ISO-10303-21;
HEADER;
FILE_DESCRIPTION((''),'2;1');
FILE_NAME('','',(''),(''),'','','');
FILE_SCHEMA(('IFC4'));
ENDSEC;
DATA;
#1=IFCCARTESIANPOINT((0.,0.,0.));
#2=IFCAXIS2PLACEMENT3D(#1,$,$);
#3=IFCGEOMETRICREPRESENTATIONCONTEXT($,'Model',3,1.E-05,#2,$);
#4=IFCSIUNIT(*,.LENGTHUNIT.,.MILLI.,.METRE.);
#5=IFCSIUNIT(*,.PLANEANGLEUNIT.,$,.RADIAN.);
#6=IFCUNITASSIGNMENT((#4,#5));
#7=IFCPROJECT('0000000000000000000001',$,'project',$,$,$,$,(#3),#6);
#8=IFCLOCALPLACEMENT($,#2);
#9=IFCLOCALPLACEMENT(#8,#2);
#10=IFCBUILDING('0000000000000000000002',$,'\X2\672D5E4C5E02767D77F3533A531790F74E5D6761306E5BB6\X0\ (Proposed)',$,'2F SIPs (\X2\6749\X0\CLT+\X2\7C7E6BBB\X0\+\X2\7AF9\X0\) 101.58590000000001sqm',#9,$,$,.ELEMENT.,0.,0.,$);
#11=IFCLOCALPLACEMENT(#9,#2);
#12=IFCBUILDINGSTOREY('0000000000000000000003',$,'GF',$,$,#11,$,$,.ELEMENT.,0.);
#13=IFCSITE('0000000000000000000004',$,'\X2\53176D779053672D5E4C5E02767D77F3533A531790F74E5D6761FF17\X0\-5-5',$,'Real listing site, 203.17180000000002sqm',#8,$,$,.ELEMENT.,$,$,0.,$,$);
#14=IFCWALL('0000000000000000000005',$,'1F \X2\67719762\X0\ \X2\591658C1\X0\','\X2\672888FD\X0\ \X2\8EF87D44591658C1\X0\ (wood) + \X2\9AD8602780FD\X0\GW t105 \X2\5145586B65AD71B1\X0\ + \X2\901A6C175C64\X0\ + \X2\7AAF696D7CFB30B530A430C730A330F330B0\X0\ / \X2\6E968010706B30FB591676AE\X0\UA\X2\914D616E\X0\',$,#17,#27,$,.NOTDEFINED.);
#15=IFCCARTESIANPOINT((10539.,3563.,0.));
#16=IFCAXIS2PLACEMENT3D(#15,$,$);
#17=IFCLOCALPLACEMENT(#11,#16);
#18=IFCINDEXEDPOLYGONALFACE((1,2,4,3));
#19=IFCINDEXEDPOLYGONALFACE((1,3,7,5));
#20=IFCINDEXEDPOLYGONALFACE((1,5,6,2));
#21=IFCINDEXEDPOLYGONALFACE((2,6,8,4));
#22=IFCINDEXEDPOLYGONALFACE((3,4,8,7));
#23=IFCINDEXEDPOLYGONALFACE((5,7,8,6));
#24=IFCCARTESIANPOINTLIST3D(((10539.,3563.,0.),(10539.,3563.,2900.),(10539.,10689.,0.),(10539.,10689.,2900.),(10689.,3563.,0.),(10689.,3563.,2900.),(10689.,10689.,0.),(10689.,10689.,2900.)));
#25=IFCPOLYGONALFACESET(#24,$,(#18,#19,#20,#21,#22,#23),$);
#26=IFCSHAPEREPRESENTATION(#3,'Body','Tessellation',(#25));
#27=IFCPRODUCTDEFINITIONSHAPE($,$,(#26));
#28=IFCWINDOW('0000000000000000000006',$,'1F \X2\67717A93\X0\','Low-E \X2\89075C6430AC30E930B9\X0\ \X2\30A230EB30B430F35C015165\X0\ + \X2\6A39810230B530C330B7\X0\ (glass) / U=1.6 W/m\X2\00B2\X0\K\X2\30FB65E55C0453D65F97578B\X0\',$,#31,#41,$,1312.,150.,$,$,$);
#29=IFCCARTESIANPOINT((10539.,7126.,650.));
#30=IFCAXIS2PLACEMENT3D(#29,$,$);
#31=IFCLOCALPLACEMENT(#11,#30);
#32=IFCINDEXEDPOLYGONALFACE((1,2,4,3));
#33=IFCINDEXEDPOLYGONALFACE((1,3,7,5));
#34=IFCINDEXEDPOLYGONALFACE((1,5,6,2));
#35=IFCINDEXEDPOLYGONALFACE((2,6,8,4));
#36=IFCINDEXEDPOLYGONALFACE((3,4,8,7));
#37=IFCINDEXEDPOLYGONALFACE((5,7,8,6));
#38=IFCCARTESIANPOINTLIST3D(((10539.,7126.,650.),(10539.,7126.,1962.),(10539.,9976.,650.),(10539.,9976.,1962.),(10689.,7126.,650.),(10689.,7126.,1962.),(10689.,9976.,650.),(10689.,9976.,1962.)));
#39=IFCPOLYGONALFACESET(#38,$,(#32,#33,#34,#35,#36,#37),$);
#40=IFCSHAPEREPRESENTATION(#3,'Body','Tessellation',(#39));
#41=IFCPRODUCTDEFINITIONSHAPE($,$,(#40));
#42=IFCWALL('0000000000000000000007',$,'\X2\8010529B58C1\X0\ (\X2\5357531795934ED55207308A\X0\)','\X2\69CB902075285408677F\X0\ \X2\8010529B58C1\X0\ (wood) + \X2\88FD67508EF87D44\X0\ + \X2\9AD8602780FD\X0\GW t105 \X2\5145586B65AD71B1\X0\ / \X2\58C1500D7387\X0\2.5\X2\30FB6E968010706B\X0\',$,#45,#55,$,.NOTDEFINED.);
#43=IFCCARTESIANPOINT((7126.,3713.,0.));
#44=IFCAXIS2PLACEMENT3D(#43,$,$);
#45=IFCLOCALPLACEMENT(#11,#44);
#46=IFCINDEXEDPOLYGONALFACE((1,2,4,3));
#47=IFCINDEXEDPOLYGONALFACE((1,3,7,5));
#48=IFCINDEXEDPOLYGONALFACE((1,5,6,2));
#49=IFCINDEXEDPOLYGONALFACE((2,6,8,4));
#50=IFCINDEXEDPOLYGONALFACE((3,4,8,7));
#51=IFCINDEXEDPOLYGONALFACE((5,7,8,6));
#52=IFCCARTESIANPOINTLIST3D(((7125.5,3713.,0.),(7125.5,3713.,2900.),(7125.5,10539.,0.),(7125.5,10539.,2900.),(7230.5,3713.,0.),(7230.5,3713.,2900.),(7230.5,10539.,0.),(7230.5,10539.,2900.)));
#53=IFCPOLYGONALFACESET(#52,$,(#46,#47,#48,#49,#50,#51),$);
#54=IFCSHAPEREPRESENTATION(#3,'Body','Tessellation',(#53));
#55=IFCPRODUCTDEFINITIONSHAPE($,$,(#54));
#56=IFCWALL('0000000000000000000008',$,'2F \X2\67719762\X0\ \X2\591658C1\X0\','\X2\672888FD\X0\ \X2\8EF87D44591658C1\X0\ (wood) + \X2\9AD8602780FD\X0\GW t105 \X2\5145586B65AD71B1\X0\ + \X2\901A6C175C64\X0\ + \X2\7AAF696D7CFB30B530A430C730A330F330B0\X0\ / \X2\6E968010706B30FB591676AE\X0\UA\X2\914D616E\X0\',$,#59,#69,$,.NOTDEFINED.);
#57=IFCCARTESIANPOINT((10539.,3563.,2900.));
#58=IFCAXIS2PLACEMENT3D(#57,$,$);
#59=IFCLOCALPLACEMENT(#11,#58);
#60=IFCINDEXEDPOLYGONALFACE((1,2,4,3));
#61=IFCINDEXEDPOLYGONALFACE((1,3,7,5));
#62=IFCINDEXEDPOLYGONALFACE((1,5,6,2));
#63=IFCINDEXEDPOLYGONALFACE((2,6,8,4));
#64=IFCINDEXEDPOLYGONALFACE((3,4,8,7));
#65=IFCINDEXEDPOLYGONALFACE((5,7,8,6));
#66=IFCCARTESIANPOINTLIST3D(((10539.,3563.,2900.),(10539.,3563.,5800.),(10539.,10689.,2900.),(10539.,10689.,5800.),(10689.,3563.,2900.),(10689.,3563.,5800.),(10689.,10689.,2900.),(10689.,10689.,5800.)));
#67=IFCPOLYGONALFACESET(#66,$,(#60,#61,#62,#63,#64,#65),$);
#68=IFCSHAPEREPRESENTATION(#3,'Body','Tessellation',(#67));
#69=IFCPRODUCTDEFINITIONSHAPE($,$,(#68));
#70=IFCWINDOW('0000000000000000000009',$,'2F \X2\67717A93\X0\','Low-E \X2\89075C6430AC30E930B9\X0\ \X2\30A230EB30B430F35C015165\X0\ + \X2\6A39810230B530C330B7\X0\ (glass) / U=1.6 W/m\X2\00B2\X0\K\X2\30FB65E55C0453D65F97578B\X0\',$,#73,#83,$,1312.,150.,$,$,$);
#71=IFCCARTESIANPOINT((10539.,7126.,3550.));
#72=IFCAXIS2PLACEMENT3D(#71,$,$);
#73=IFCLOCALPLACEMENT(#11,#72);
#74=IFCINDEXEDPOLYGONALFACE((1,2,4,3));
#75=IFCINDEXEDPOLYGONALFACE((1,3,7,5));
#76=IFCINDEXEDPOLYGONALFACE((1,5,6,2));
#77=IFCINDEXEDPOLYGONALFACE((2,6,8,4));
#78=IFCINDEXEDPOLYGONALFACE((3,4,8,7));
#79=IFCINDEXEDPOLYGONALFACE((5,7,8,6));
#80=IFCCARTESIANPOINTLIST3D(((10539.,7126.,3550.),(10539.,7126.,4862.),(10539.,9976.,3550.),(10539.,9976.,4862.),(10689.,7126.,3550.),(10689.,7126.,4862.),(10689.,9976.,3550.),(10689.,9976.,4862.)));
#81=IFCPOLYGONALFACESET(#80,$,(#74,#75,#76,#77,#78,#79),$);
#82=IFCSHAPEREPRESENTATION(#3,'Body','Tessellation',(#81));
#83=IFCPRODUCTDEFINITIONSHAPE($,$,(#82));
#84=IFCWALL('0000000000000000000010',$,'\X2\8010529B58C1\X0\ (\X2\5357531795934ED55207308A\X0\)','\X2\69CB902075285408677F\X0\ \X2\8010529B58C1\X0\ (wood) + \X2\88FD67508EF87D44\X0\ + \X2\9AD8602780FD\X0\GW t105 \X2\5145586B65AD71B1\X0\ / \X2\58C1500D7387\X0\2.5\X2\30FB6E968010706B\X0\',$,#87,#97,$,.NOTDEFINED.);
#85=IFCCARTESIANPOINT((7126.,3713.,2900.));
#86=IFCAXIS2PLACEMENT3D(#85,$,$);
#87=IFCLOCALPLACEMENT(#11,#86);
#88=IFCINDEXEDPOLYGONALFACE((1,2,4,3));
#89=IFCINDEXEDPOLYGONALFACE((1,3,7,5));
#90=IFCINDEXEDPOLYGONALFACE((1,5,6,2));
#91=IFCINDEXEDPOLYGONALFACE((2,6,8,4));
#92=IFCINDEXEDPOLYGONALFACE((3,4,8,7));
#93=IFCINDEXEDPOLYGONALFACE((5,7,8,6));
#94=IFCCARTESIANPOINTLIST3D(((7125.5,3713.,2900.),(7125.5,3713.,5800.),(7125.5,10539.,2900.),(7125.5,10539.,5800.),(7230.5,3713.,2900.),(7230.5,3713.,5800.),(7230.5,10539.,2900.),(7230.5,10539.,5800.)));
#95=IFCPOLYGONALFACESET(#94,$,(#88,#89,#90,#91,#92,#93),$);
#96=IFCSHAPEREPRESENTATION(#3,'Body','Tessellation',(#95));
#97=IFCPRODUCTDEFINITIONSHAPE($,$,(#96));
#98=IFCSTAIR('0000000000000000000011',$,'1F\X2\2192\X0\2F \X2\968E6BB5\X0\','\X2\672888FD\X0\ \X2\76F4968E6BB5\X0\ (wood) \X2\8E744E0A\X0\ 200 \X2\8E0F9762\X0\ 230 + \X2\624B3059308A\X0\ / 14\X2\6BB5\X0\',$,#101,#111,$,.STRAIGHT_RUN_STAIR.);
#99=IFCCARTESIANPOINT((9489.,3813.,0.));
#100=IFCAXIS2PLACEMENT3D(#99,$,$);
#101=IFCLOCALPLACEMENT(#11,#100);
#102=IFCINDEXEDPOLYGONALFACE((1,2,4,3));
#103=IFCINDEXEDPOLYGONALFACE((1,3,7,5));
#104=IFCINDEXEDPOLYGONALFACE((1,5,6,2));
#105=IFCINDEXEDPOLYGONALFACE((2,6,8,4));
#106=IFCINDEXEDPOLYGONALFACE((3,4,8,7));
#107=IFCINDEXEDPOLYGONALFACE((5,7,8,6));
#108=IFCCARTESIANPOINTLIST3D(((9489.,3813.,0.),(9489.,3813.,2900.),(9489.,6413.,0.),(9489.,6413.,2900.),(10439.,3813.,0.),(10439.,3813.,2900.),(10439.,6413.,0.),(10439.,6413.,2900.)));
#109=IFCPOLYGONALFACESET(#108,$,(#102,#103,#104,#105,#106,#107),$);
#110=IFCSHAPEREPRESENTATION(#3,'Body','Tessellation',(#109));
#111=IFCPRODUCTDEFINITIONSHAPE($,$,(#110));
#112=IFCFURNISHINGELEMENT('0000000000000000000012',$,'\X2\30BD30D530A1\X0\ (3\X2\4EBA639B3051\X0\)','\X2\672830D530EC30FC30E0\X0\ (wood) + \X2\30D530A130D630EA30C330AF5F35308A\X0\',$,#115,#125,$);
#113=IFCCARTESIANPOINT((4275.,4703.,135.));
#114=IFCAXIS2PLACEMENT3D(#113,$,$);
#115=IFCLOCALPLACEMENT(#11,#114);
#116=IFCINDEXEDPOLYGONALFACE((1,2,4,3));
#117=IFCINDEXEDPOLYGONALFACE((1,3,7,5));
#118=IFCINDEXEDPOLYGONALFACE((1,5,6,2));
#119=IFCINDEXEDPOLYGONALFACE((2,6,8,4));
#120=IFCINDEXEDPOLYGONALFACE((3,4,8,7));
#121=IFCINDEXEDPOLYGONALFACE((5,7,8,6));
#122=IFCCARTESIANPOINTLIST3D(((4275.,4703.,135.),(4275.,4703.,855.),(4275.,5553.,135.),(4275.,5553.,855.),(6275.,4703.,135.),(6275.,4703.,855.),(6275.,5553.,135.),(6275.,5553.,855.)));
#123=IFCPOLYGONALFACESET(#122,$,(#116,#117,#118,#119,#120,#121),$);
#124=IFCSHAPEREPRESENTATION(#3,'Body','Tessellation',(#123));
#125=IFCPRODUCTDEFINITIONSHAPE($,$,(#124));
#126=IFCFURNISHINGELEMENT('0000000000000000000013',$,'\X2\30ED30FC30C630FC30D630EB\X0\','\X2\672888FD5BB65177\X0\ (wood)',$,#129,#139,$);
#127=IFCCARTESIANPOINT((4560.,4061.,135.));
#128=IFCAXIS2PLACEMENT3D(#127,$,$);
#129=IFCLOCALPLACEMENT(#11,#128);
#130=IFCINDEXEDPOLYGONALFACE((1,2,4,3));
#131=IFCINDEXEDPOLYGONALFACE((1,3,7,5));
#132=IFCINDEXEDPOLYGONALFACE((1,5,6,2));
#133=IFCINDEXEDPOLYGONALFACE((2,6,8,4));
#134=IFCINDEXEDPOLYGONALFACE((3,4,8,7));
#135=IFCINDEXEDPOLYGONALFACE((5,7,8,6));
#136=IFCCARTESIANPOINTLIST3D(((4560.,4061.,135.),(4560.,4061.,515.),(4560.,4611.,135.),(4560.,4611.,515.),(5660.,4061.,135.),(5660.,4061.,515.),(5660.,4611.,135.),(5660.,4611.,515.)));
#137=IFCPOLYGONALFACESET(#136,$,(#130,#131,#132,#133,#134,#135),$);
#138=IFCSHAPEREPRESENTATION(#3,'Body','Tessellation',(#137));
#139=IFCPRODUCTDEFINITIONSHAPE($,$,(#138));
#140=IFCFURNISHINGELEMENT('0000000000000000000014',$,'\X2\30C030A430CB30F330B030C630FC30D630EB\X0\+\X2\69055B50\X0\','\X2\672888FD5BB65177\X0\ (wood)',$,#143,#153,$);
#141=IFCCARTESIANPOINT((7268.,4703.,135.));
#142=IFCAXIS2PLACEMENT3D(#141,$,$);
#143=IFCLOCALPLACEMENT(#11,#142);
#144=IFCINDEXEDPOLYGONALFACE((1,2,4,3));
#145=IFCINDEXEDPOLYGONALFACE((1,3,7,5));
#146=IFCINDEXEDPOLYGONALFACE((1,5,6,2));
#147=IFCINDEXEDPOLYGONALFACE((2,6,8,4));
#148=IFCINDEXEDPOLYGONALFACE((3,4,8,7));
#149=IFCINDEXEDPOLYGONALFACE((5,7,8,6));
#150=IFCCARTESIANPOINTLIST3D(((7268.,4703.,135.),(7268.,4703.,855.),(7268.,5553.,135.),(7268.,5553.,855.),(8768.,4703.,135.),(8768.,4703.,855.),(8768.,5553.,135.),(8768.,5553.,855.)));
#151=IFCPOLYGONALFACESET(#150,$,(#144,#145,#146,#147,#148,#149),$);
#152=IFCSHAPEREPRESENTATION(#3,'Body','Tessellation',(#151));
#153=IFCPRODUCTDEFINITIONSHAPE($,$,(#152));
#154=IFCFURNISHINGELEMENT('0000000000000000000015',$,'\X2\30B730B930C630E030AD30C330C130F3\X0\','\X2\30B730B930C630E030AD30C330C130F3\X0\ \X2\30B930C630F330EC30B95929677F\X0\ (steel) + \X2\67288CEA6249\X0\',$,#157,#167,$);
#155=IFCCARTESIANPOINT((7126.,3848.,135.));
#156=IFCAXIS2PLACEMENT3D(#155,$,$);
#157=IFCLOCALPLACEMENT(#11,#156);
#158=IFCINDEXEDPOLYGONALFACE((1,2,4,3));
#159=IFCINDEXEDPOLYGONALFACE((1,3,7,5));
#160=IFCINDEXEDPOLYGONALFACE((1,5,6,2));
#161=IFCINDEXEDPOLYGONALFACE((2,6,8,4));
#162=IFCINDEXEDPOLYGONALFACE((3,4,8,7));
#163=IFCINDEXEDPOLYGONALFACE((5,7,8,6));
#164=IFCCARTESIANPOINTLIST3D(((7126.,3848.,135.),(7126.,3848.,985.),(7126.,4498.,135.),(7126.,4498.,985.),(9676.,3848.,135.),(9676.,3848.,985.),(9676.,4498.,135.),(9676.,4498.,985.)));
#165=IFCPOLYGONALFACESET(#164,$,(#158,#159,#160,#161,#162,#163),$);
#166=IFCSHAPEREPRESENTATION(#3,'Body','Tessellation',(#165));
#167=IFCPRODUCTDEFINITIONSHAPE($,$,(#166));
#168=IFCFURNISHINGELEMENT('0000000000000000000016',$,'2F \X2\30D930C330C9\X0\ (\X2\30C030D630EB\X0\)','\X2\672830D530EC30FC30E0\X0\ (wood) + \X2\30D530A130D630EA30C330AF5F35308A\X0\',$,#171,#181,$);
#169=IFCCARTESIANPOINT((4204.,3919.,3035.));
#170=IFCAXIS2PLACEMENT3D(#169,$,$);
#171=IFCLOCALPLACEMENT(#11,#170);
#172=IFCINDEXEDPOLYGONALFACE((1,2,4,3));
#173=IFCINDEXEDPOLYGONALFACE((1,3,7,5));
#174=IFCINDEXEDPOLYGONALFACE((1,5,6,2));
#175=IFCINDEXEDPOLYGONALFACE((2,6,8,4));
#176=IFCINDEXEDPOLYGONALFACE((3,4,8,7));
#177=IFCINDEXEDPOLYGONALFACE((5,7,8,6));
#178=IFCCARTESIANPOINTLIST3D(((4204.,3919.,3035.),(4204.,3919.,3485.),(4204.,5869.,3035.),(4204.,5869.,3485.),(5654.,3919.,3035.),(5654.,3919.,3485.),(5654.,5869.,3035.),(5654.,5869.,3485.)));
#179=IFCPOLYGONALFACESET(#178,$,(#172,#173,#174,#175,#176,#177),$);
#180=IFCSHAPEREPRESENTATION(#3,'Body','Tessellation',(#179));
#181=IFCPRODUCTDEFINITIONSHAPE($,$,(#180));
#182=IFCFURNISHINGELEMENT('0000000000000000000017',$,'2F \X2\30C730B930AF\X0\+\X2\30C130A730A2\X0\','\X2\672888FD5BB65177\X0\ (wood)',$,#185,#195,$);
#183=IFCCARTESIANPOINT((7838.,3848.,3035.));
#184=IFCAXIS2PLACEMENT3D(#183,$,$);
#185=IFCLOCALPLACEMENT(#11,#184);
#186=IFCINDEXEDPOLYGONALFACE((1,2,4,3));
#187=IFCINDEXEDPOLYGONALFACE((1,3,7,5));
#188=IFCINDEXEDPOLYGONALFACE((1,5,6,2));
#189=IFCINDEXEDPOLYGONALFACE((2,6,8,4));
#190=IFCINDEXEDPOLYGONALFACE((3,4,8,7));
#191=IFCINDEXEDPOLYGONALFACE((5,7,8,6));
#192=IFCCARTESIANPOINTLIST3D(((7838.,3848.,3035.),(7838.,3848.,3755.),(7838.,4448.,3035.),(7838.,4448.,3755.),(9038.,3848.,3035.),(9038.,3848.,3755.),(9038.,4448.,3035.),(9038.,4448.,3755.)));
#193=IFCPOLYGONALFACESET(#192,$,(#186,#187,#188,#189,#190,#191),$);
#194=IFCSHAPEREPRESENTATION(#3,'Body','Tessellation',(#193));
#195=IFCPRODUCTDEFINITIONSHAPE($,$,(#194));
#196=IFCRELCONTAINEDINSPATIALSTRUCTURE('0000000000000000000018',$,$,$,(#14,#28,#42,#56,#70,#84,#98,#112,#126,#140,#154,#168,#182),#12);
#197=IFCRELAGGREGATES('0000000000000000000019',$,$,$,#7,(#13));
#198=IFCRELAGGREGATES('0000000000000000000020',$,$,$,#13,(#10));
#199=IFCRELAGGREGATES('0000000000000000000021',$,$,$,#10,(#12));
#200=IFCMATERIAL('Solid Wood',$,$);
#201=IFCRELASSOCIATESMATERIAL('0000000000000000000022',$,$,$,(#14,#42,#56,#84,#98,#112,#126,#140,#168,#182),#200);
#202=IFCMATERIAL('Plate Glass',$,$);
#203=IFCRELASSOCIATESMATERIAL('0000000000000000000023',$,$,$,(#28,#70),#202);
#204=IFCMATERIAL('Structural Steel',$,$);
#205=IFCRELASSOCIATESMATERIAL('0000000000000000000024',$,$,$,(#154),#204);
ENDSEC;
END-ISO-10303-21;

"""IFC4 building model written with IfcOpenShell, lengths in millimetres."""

from ifc_helpers import new_model, si_unit, frame, frame_2d, origin, place, context, project, spatial, rectangle, extrude, material, element, fill, save


model = new_model("IFC4")

# Units and contexts
model_context = context("Model", 3, precision=1e-05, world=origin())
ifc_project = project(units=[si_unit("LENGTHUNIT", "METRE", prefix="MILLI"), si_unit("PLANEANGLEUNIT", "RADIAN")], contexts=[model_context])

# Site, building, storey
site_placement = place(None, origin())
site = spatial("IfcSite", under=ifc_project, at=site_placement, Name="北海道札幌市白石区北郷九条７-5-5", ObjectType="Real listing site, 203.17180000000002sqm", CompositionType="ELEMENT", RefElevation=0.0)
building_placement = place(site_placement, origin())
building = spatial("IfcBuilding", under=site, at=building_placement, Name="札幌市白石区北郷九条の家 (Proposed)", ObjectType="2F SIPs (杉CLT+籾殻+竹) 101.58590000000001sqm", CompositionType="ELEMENT", ElevationOfRefHeight=0.0, ElevationOfTerrain=0.0)
storey_placement = place(building_placement, origin())
storey = spatial("IfcBuildingStorey", under=building, at=storey_placement, Name="GF", CompositionType="ELEMENT", Elevation=0.0)

# Wall, opening, window
ifc_material_1 = material(Name="Solid Wood")
wall_1_placement = place(storey_placement, frame((10539.0, 3563.0, 0.0)))
wall_1 = element("IfcWall", 1, at=wall_1_placement, inside=storey, material=ifc_material_1, Name="1F 東面 外壁", Description="木製 軸組外壁 (wood) + 高性能GW t105 充填断熱 + 通気層 + 窯業系サイディング / 準耐火・外皮UA配慮", PredefinedType="NOTDEFINED", context=model_context, shape_type="SweptSolid", body=[
    extrude(rectangle(XDim=150.0, YDim=7126.0, at=frame_2d((75.0, 3563.0))), frame((10539.0, 3563.0, 0.0)), (0.0, 0.0, 1.0), 2900.0),
])
opening_1_placement = place(storey_placement, frame((10539.0, 7126.0, 650.0)))
opening_1 = element("IfcOpeningElement", 2, at=opening_1_placement, cuts=wall_1, PredefinedType="NOTDEFINED", context=model_context, shape_type="SweptSolid", body=[
    extrude(rectangle(XDim=150.0, YDim=2850.0, at=frame_2d((75.0, 1425.0))), frame((10539.0, 7126.0, 650.0)), (0.0, 0.0, 1.0), 1312.0),
])
ifc_material_2 = material(Name="Plate Glass")
window_1_placement = place(storey_placement, frame((10539.0, 7126.0, 650.0)))
window_1 = element("IfcWindow", 3, at=window_1_placement, inside=storey, material=ifc_material_2, Name="1F 東窓", Description="Low-E 複層ガラス アルゴン封入 + 樹脂サッシ (glass) / U=1.6 W/m²K・日射取得型", OverallHeight=1312.0, OverallWidth=150.0, context=model_context, shape_type="SweptSolid", body=[
    extrude(rectangle(XDim=150.0, YDim=2850.0, at=frame_2d((75.0, 1425.0))), frame((10539.0, 7126.0, 650.0)), (0.0, 0.0, 1.0), 1312.0),
])
fill(opening_1, window_1)

# Wall
wall_2_placement = place(storey_placement, frame((7126.0, 3713.0, 0.0)))
element("IfcWall", 4, at=wall_2_placement, inside=storey, material=ifc_material_1, Name="耐力壁 (南北間仕切り)", Description="構造用合板 耐力壁 (wood) + 製材軸組 + 高性能GW t105 充填断熱 / 壁倍率2.5・準耐火", PredefinedType="NOTDEFINED", context=model_context, shape_type="SweptSolid", body=[
    extrude(rectangle(XDim=105.0, YDim=6826.0, at=frame_2d((52.0, 3413.0))), frame((7126.0, 3713.0, 0.0)), (0.0, 0.0, 1.0), 2900.0),
])

# Wall, opening, window
wall_3_placement = place(storey_placement, frame((10539.0, 3563.0, 2900.0)))
wall_3 = element("IfcWall", 5, at=wall_3_placement, inside=storey, material=ifc_material_1, Name="2F 東面 外壁", Description="木製 軸組外壁 (wood) + 高性能GW t105 充填断熱 + 通気層 + 窯業系サイディング / 準耐火・外皮UA配慮", PredefinedType="NOTDEFINED", context=model_context, shape_type="SweptSolid", body=[
    extrude(rectangle(XDim=150.0, YDim=7126.0, at=frame_2d((75.0, 3563.0))), frame((10539.0, 3563.0, 2900.0)), (0.0, 0.0, 1.0), 2900.0),
])
opening_2_placement = place(storey_placement, frame((10539.0, 7126.0, 3550.0)))
opening_2 = element("IfcOpeningElement", 6, at=opening_2_placement, cuts=wall_3, PredefinedType="NOTDEFINED", context=model_context, shape_type="SweptSolid", body=[
    extrude(rectangle(XDim=150.0, YDim=2850.0, at=frame_2d((75.0, 1425.0))), frame((10539.0, 7126.0, 3550.0)), (0.0, 0.0, 1.0), 1312.0),
])
window_2_placement = place(storey_placement, frame((10539.0, 7126.0, 3550.0)))
window_2 = element("IfcWindow", 7, at=window_2_placement, inside=storey, material=ifc_material_2, Name="2F 東窓", Description="Low-E 複層ガラス アルゴン封入 + 樹脂サッシ (glass) / U=1.6 W/m²K・日射取得型", OverallHeight=1312.0, OverallWidth=150.0, context=model_context, shape_type="SweptSolid", body=[
    extrude(rectangle(XDim=150.0, YDim=2850.0, at=frame_2d((75.0, 1425.0))), frame((10539.0, 7126.0, 3550.0)), (0.0, 0.0, 1.0), 1312.0),
])
fill(opening_2, window_2)

# Wall
wall_4_placement = place(storey_placement, frame((7126.0, 3713.0, 2900.0)))
element("IfcWall", 8, at=wall_4_placement, inside=storey, material=ifc_material_1, Name="耐力壁 (南北間仕切り)", Description="構造用合板 耐力壁 (wood) + 製材軸組 + 高性能GW t105 充填断熱 / 壁倍率2.5・準耐火", PredefinedType="NOTDEFINED", context=model_context, shape_type="SweptSolid", body=[
    extrude(rectangle(XDim=105.0, YDim=6826.0, at=frame_2d((52.0, 3413.0))), frame((7126.0, 3713.0, 2900.0)), (0.0, 0.0, 1.0), 2900.0),
])

# Stair
stair_placement = place(storey_placement, frame((9489.0, 3813.0, 0.0)))
element("IfcStair", 9, at=stair_placement, inside=storey, material=ifc_material_1, Name="1F→2F 階段", Description="木製 直階段 (wood) 蹴上 200 踏面 230 + 手すり / 14段", PredefinedType="STRAIGHT_RUN_STAIR", context=model_context, shape_type="SweptSolid", body=[
    extrude(rectangle(XDim=950.0, YDim=2600.0, at=frame_2d((475.0, 1300.0))), frame((9489.0, 3813.0, 0.0)), (0.0, 0.0, 1.0), 2900.0),
])

# Furnishing elements
furnishing_1_placement = place(storey_placement, frame((4275.0, 4703.0, 135.0)))
element("IfcFurnishingElement", 10, at=furnishing_1_placement, inside=storey, material=ifc_material_1, Name="ソファ (3人掛け)", Description="木フレーム (wood) + ファブリック張り", context=model_context, shape_type="SweptSolid", body=[
    extrude(rectangle(XDim=2000.0, YDim=850.0, at=frame_2d((1000.0, 425.0))), frame((4275.0, 4703.0, 135.0)), (0.0, 0.0, 1.0), 720.0),
])
furnishing_2_placement = place(storey_placement, frame((4560.0, 4061.0, 135.0)))
element("IfcFurnishingElement", 11, at=furnishing_2_placement, inside=storey, material=ifc_material_1, Name="ローテーブル", Description="木製家具 (wood)", context=model_context, shape_type="SweptSolid", body=[
    extrude(rectangle(XDim=1100.0, YDim=550.0, at=frame_2d((550.0, 275.0))), frame((4560.0, 4061.0, 135.0)), (0.0, 0.0, 1.0), 380.0),
])
furnishing_3_placement = place(storey_placement, frame((7268.0, 4703.0, 135.0)))
element("IfcFurnishingElement", 12, at=furnishing_3_placement, inside=storey, material=ifc_material_1, Name="ダイニングテーブル+椅子", Description="木製家具 (wood)", context=model_context, shape_type="SweptSolid", body=[
    extrude(rectangle(XDim=1500.0, YDim=850.0, at=frame_2d((750.0, 425.0))), frame((7268.0, 4703.0, 135.0)), (0.0, 0.0, 1.0), 720.0),
])
ifc_material_3 = material(Name="Structural Steel")
furnishing_4_placement = place(storey_placement, frame((7126.0, 3848.0, 135.0)))
element("IfcFurnishingElement", 13, at=furnishing_4_placement, inside=storey, material=ifc_material_3, Name="システムキッチン", Description="システムキッチン ステンレス天板 (steel) + 木質扉", context=model_context, shape_type="SweptSolid", body=[
    extrude(rectangle(XDim=2550.0, YDim=650.0, at=frame_2d((1275.0, 325.0))), frame((7126.0, 3848.0, 135.0)), (0.0, 0.0, 1.0), 850.0),
])
furnishing_5_placement = place(storey_placement, frame((4204.0, 3919.0, 3035.0)))
element("IfcFurnishingElement", 14, at=furnishing_5_placement, inside=storey, material=ifc_material_1, Name="2F ベッド (ダブル)", Description="木フレーム (wood) + ファブリック張り", context=model_context, shape_type="SweptSolid", body=[
    extrude(rectangle(XDim=1450.0, YDim=1950.0, at=frame_2d((725.0, 975.0))), frame((4204.0, 3919.0, 3035.0)), (0.0, 0.0, 1.0), 450.0),
])
furnishing_6_placement = place(storey_placement, frame((7838.0, 3848.0, 3035.0)))
element("IfcFurnishingElement", 15, at=furnishing_6_placement, inside=storey, material=ifc_material_1, Name="2F デスク+チェア", Description="木製家具 (wood)", context=model_context, shape_type="SweptSolid", body=[
    extrude(rectangle(XDim=1200.0, YDim=600.0, at=frame_2d((600.0, 300.0))), frame((7838.0, 3848.0, 3035.0)), (0.0, 0.0, 1.0), 720.0),
])

save(model, "model.ifc")
